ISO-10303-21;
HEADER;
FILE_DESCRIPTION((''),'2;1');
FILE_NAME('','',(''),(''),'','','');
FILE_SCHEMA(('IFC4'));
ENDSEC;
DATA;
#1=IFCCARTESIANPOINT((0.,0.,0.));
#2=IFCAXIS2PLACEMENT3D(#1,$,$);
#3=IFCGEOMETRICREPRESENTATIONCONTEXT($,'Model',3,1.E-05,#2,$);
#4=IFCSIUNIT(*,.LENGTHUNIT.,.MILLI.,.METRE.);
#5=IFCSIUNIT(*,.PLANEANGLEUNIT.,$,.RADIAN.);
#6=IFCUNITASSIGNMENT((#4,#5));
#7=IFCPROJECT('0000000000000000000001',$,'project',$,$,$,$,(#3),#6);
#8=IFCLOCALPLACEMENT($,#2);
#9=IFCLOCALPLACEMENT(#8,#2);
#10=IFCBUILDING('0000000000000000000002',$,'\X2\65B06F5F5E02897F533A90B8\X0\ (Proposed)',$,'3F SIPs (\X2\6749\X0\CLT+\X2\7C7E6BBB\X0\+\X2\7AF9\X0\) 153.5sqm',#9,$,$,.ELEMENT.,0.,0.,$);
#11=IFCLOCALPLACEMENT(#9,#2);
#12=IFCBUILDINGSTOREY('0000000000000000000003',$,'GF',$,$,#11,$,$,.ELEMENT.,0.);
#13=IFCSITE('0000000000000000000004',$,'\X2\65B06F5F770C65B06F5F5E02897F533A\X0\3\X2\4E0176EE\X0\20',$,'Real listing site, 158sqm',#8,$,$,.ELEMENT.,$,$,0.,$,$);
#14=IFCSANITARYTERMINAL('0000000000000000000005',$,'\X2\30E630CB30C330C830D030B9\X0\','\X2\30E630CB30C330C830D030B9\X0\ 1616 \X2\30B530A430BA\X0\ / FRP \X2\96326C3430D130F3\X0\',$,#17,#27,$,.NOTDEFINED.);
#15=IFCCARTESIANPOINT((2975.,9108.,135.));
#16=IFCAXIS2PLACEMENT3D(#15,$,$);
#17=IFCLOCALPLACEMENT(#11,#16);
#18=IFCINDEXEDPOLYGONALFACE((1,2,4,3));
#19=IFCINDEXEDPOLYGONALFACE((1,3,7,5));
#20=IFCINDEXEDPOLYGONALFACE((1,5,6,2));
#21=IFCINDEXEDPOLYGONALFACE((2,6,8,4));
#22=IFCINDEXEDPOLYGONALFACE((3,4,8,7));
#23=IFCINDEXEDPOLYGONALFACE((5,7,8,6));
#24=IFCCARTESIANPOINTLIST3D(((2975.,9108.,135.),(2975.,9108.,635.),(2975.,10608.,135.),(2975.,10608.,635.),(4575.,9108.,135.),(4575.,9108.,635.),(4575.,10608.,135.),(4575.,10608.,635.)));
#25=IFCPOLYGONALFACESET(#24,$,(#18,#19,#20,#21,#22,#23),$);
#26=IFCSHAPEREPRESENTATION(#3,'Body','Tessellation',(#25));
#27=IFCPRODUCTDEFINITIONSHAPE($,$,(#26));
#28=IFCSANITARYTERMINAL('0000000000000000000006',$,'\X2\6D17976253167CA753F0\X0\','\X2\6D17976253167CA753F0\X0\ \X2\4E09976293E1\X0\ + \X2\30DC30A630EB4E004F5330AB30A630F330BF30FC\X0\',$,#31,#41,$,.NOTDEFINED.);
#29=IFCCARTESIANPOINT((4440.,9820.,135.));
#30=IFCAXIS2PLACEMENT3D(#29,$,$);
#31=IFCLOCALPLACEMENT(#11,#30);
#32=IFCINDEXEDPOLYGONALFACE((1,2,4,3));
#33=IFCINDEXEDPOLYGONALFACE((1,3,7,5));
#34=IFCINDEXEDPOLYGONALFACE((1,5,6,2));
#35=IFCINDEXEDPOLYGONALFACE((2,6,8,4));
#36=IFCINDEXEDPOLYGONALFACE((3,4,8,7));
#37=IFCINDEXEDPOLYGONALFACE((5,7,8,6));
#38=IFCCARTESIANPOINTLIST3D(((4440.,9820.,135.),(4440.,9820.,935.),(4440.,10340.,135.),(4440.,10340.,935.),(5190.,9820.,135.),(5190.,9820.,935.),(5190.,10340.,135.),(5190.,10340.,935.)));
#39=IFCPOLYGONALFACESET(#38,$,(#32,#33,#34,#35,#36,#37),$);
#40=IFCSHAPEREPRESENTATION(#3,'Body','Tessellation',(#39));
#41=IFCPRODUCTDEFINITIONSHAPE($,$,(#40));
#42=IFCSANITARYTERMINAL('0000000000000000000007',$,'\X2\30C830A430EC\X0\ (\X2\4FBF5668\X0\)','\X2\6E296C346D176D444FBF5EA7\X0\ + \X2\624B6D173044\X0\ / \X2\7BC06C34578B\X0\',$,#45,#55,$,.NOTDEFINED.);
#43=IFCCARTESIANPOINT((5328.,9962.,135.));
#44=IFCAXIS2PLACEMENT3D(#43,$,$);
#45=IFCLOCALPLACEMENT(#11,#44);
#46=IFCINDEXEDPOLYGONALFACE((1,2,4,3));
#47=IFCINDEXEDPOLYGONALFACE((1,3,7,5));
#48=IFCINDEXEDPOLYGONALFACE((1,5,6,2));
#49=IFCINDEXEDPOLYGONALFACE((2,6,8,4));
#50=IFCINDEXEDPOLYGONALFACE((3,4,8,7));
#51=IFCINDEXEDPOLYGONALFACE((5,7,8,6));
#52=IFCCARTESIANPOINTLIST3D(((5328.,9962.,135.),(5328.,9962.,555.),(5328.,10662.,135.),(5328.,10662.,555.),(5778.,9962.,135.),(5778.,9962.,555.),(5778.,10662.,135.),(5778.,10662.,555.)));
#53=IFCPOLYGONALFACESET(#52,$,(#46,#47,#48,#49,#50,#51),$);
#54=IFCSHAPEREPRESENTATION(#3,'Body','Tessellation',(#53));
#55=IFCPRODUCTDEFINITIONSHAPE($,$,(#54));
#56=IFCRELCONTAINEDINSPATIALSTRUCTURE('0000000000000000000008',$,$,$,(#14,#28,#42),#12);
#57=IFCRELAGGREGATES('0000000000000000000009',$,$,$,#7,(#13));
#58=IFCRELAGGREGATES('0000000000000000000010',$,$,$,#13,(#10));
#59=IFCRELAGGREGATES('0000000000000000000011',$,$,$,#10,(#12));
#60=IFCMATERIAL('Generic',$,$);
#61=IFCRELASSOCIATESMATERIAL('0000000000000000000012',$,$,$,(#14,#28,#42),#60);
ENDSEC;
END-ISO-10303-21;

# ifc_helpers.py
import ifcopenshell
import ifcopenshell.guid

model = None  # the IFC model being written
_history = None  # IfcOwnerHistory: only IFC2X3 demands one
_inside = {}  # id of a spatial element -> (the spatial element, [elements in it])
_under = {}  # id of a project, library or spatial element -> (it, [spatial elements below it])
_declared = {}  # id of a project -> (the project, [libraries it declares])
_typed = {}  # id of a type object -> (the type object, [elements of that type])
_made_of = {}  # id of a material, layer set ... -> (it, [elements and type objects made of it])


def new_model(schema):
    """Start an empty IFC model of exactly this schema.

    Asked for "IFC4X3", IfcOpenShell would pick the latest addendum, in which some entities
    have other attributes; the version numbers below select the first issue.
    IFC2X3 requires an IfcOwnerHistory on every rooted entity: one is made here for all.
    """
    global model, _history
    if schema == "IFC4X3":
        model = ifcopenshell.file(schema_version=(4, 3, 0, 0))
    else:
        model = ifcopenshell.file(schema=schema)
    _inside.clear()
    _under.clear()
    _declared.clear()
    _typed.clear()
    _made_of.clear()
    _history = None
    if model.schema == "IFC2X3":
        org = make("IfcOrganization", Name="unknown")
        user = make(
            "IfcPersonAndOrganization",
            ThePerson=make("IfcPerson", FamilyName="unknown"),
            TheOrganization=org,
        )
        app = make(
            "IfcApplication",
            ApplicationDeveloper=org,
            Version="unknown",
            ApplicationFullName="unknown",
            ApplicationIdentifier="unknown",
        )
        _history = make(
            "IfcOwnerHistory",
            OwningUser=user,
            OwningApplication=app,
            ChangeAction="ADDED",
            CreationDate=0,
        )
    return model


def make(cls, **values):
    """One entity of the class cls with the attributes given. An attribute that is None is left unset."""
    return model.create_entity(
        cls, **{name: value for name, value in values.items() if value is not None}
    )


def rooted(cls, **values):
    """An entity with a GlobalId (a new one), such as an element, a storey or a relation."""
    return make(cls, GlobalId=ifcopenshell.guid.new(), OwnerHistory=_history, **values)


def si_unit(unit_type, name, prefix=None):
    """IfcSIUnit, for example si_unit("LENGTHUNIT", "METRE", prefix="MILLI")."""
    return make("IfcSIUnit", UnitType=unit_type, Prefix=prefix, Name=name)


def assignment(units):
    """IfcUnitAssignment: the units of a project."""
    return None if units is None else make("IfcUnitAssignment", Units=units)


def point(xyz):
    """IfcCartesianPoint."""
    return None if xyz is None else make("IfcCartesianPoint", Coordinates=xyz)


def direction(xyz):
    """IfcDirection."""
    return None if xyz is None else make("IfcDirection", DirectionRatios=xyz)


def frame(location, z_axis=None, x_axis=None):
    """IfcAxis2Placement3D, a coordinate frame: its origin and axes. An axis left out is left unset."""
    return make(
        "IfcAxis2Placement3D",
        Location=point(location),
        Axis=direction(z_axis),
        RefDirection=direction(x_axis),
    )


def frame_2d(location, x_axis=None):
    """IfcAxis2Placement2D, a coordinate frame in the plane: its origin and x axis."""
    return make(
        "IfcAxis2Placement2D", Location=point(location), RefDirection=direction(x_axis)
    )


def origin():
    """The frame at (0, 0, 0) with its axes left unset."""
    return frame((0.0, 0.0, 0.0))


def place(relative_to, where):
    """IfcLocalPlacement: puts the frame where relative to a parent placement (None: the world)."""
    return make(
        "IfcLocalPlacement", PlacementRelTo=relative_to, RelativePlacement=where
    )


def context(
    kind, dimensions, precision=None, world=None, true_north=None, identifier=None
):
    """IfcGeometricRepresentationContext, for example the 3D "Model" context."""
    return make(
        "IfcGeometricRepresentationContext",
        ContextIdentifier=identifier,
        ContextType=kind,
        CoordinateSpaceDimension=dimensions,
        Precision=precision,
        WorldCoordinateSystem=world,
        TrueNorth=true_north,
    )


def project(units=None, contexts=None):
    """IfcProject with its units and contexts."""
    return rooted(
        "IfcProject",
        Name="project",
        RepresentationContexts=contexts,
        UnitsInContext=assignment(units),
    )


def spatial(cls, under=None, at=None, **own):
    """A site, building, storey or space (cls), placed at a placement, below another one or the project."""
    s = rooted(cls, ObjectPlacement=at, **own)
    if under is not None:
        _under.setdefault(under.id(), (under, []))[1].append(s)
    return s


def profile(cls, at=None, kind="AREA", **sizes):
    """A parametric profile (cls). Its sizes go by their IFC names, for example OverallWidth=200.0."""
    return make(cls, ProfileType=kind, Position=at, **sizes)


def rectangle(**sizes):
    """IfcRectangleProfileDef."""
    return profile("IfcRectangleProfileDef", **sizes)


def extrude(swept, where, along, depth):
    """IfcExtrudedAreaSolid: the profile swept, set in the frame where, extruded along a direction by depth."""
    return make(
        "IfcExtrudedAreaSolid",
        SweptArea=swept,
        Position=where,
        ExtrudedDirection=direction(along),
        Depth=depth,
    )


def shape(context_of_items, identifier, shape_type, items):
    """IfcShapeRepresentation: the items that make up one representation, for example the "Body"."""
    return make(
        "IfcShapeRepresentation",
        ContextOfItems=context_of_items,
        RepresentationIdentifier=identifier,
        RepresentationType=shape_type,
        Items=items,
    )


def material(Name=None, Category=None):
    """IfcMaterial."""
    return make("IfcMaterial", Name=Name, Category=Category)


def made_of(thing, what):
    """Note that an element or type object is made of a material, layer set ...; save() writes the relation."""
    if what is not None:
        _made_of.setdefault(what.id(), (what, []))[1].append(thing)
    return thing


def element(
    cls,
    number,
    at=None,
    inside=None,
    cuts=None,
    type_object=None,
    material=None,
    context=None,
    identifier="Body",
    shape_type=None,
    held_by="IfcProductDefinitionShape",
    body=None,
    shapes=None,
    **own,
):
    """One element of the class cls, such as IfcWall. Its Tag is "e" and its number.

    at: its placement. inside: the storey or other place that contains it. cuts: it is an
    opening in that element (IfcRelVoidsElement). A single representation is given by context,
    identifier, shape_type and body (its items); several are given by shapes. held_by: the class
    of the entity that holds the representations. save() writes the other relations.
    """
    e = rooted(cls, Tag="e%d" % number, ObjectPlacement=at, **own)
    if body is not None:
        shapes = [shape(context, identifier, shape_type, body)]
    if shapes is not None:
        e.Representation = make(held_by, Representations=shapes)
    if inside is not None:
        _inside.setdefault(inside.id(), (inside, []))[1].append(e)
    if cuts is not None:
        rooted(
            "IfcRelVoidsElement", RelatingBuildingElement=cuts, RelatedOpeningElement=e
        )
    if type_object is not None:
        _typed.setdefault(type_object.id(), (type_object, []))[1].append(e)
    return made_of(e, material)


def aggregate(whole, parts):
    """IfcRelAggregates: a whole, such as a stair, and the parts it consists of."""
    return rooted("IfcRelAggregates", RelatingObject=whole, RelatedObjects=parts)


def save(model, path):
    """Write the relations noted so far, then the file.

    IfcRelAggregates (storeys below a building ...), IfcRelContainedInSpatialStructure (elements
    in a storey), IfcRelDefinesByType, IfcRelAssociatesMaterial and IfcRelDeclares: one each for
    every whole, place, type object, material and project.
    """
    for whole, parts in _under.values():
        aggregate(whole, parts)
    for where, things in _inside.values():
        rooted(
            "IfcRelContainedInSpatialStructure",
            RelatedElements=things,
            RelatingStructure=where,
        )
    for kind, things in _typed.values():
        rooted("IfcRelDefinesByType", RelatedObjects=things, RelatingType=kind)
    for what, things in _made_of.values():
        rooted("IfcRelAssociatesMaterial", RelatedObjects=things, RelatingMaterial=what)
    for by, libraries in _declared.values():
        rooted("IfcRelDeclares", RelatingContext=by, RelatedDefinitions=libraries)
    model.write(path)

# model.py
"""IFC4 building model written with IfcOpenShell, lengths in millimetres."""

from ifc_helpers import new_model, si_unit, frame, frame_2d, origin, place, context, project, spatial, rectangle, extrude, material, element, save


model = new_model("IFC4")

# Units and contexts
model_context = context("Model", 3, precision=1e-05, world=origin())
ifc_project = project(units=[si_unit("LENGTHUNIT", "METRE", prefix="MILLI"), si_unit("PLANEANGLEUNIT", "RADIAN")], contexts=[model_context])

# Site, building, storey
site_placement = place(None, origin())
site = spatial("IfcSite", under=ifc_project, at=site_placement, Name="新潟県新潟市西区3丁目20", ObjectType="Real listing site, 158sqm", CompositionType="ELEMENT", RefElevation=0.0)
building_placement = place(site_placement, origin())
building = spatial("IfcBuilding", under=site, at=building_placement, Name="新潟市西区邸 (Proposed)", ObjectType="3F SIPs (杉CLT+籾殻+竹) 153.5sqm", CompositionType="ELEMENT", ElevationOfRefHeight=0.0, ElevationOfTerrain=0.0)
storey_placement = place(building_placement, origin())
storey = spatial("IfcBuildingStorey", under=building, at=storey_placement, Name="GF", CompositionType="ELEMENT", Elevation=0.0)

# Shared definitions
ifc_material_1 = material(Name="Generic")

# Sanitary terminals
sanitary_terminal_1_placement = place(storey_placement, frame((2975.0, 9108.0, 135.0)))
element("IfcSanitaryTerminal", 1, at=sanitary_terminal_1_placement, inside=storey, material=ifc_material_1, Name="ユニットバス", Description="ユニットバス 1616 サイズ / FRP 防水パン", PredefinedType="NOTDEFINED", context=model_context, shape_type="SweptSolid", body=[
    extrude(rectangle(XDim=1600.0, YDim=1500.0, at=frame_2d((800.0, 750.0))), frame((2975.0, 9108.0, 135.0)), (0.0, 0.0, 1.0), 500.0),
])
sanitary_terminal_2_placement = place(storey_placement, frame((4440.0, 9820.0, 135.0)))
element("IfcSanitaryTerminal", 2, at=sanitary_terminal_2_placement, inside=storey, material=ifc_material_1, Name="洗面化粧台", Description="洗面化粧台 三面鏡 + ボウル一体カウンター", PredefinedType="NOTDEFINED", context=model_context, shape_type="SweptSolid", body=[
    extrude(rectangle(XDim=750.0, YDim=520.0, at=frame_2d((375.0, 260.0))), frame((4440.0, 9820.0, 135.0)), (0.0, 0.0, 1.0), 800.0),
])
sanitary_terminal_3_placement = place(storey_placement, frame((5328.0, 9962.0, 135.0)))
element("IfcSanitaryTerminal", 3, at=sanitary_terminal_3_placement, inside=storey, material=ifc_material_1, Name="トイレ (便器)", Description="温水洗浄便座 + 手洗い / 節水型", PredefinedType="NOTDEFINED", context=model_context, shape_type="SweptSolid", body=[
    extrude(rectangle(XDim=450.0, YDim=700.0, at=frame_2d((225.0, 350.0))), frame((5328.0, 9962.0, 135.0)), (0.0, 0.0, 1.0), 420.0),
])

save(model, "model.ifc")
